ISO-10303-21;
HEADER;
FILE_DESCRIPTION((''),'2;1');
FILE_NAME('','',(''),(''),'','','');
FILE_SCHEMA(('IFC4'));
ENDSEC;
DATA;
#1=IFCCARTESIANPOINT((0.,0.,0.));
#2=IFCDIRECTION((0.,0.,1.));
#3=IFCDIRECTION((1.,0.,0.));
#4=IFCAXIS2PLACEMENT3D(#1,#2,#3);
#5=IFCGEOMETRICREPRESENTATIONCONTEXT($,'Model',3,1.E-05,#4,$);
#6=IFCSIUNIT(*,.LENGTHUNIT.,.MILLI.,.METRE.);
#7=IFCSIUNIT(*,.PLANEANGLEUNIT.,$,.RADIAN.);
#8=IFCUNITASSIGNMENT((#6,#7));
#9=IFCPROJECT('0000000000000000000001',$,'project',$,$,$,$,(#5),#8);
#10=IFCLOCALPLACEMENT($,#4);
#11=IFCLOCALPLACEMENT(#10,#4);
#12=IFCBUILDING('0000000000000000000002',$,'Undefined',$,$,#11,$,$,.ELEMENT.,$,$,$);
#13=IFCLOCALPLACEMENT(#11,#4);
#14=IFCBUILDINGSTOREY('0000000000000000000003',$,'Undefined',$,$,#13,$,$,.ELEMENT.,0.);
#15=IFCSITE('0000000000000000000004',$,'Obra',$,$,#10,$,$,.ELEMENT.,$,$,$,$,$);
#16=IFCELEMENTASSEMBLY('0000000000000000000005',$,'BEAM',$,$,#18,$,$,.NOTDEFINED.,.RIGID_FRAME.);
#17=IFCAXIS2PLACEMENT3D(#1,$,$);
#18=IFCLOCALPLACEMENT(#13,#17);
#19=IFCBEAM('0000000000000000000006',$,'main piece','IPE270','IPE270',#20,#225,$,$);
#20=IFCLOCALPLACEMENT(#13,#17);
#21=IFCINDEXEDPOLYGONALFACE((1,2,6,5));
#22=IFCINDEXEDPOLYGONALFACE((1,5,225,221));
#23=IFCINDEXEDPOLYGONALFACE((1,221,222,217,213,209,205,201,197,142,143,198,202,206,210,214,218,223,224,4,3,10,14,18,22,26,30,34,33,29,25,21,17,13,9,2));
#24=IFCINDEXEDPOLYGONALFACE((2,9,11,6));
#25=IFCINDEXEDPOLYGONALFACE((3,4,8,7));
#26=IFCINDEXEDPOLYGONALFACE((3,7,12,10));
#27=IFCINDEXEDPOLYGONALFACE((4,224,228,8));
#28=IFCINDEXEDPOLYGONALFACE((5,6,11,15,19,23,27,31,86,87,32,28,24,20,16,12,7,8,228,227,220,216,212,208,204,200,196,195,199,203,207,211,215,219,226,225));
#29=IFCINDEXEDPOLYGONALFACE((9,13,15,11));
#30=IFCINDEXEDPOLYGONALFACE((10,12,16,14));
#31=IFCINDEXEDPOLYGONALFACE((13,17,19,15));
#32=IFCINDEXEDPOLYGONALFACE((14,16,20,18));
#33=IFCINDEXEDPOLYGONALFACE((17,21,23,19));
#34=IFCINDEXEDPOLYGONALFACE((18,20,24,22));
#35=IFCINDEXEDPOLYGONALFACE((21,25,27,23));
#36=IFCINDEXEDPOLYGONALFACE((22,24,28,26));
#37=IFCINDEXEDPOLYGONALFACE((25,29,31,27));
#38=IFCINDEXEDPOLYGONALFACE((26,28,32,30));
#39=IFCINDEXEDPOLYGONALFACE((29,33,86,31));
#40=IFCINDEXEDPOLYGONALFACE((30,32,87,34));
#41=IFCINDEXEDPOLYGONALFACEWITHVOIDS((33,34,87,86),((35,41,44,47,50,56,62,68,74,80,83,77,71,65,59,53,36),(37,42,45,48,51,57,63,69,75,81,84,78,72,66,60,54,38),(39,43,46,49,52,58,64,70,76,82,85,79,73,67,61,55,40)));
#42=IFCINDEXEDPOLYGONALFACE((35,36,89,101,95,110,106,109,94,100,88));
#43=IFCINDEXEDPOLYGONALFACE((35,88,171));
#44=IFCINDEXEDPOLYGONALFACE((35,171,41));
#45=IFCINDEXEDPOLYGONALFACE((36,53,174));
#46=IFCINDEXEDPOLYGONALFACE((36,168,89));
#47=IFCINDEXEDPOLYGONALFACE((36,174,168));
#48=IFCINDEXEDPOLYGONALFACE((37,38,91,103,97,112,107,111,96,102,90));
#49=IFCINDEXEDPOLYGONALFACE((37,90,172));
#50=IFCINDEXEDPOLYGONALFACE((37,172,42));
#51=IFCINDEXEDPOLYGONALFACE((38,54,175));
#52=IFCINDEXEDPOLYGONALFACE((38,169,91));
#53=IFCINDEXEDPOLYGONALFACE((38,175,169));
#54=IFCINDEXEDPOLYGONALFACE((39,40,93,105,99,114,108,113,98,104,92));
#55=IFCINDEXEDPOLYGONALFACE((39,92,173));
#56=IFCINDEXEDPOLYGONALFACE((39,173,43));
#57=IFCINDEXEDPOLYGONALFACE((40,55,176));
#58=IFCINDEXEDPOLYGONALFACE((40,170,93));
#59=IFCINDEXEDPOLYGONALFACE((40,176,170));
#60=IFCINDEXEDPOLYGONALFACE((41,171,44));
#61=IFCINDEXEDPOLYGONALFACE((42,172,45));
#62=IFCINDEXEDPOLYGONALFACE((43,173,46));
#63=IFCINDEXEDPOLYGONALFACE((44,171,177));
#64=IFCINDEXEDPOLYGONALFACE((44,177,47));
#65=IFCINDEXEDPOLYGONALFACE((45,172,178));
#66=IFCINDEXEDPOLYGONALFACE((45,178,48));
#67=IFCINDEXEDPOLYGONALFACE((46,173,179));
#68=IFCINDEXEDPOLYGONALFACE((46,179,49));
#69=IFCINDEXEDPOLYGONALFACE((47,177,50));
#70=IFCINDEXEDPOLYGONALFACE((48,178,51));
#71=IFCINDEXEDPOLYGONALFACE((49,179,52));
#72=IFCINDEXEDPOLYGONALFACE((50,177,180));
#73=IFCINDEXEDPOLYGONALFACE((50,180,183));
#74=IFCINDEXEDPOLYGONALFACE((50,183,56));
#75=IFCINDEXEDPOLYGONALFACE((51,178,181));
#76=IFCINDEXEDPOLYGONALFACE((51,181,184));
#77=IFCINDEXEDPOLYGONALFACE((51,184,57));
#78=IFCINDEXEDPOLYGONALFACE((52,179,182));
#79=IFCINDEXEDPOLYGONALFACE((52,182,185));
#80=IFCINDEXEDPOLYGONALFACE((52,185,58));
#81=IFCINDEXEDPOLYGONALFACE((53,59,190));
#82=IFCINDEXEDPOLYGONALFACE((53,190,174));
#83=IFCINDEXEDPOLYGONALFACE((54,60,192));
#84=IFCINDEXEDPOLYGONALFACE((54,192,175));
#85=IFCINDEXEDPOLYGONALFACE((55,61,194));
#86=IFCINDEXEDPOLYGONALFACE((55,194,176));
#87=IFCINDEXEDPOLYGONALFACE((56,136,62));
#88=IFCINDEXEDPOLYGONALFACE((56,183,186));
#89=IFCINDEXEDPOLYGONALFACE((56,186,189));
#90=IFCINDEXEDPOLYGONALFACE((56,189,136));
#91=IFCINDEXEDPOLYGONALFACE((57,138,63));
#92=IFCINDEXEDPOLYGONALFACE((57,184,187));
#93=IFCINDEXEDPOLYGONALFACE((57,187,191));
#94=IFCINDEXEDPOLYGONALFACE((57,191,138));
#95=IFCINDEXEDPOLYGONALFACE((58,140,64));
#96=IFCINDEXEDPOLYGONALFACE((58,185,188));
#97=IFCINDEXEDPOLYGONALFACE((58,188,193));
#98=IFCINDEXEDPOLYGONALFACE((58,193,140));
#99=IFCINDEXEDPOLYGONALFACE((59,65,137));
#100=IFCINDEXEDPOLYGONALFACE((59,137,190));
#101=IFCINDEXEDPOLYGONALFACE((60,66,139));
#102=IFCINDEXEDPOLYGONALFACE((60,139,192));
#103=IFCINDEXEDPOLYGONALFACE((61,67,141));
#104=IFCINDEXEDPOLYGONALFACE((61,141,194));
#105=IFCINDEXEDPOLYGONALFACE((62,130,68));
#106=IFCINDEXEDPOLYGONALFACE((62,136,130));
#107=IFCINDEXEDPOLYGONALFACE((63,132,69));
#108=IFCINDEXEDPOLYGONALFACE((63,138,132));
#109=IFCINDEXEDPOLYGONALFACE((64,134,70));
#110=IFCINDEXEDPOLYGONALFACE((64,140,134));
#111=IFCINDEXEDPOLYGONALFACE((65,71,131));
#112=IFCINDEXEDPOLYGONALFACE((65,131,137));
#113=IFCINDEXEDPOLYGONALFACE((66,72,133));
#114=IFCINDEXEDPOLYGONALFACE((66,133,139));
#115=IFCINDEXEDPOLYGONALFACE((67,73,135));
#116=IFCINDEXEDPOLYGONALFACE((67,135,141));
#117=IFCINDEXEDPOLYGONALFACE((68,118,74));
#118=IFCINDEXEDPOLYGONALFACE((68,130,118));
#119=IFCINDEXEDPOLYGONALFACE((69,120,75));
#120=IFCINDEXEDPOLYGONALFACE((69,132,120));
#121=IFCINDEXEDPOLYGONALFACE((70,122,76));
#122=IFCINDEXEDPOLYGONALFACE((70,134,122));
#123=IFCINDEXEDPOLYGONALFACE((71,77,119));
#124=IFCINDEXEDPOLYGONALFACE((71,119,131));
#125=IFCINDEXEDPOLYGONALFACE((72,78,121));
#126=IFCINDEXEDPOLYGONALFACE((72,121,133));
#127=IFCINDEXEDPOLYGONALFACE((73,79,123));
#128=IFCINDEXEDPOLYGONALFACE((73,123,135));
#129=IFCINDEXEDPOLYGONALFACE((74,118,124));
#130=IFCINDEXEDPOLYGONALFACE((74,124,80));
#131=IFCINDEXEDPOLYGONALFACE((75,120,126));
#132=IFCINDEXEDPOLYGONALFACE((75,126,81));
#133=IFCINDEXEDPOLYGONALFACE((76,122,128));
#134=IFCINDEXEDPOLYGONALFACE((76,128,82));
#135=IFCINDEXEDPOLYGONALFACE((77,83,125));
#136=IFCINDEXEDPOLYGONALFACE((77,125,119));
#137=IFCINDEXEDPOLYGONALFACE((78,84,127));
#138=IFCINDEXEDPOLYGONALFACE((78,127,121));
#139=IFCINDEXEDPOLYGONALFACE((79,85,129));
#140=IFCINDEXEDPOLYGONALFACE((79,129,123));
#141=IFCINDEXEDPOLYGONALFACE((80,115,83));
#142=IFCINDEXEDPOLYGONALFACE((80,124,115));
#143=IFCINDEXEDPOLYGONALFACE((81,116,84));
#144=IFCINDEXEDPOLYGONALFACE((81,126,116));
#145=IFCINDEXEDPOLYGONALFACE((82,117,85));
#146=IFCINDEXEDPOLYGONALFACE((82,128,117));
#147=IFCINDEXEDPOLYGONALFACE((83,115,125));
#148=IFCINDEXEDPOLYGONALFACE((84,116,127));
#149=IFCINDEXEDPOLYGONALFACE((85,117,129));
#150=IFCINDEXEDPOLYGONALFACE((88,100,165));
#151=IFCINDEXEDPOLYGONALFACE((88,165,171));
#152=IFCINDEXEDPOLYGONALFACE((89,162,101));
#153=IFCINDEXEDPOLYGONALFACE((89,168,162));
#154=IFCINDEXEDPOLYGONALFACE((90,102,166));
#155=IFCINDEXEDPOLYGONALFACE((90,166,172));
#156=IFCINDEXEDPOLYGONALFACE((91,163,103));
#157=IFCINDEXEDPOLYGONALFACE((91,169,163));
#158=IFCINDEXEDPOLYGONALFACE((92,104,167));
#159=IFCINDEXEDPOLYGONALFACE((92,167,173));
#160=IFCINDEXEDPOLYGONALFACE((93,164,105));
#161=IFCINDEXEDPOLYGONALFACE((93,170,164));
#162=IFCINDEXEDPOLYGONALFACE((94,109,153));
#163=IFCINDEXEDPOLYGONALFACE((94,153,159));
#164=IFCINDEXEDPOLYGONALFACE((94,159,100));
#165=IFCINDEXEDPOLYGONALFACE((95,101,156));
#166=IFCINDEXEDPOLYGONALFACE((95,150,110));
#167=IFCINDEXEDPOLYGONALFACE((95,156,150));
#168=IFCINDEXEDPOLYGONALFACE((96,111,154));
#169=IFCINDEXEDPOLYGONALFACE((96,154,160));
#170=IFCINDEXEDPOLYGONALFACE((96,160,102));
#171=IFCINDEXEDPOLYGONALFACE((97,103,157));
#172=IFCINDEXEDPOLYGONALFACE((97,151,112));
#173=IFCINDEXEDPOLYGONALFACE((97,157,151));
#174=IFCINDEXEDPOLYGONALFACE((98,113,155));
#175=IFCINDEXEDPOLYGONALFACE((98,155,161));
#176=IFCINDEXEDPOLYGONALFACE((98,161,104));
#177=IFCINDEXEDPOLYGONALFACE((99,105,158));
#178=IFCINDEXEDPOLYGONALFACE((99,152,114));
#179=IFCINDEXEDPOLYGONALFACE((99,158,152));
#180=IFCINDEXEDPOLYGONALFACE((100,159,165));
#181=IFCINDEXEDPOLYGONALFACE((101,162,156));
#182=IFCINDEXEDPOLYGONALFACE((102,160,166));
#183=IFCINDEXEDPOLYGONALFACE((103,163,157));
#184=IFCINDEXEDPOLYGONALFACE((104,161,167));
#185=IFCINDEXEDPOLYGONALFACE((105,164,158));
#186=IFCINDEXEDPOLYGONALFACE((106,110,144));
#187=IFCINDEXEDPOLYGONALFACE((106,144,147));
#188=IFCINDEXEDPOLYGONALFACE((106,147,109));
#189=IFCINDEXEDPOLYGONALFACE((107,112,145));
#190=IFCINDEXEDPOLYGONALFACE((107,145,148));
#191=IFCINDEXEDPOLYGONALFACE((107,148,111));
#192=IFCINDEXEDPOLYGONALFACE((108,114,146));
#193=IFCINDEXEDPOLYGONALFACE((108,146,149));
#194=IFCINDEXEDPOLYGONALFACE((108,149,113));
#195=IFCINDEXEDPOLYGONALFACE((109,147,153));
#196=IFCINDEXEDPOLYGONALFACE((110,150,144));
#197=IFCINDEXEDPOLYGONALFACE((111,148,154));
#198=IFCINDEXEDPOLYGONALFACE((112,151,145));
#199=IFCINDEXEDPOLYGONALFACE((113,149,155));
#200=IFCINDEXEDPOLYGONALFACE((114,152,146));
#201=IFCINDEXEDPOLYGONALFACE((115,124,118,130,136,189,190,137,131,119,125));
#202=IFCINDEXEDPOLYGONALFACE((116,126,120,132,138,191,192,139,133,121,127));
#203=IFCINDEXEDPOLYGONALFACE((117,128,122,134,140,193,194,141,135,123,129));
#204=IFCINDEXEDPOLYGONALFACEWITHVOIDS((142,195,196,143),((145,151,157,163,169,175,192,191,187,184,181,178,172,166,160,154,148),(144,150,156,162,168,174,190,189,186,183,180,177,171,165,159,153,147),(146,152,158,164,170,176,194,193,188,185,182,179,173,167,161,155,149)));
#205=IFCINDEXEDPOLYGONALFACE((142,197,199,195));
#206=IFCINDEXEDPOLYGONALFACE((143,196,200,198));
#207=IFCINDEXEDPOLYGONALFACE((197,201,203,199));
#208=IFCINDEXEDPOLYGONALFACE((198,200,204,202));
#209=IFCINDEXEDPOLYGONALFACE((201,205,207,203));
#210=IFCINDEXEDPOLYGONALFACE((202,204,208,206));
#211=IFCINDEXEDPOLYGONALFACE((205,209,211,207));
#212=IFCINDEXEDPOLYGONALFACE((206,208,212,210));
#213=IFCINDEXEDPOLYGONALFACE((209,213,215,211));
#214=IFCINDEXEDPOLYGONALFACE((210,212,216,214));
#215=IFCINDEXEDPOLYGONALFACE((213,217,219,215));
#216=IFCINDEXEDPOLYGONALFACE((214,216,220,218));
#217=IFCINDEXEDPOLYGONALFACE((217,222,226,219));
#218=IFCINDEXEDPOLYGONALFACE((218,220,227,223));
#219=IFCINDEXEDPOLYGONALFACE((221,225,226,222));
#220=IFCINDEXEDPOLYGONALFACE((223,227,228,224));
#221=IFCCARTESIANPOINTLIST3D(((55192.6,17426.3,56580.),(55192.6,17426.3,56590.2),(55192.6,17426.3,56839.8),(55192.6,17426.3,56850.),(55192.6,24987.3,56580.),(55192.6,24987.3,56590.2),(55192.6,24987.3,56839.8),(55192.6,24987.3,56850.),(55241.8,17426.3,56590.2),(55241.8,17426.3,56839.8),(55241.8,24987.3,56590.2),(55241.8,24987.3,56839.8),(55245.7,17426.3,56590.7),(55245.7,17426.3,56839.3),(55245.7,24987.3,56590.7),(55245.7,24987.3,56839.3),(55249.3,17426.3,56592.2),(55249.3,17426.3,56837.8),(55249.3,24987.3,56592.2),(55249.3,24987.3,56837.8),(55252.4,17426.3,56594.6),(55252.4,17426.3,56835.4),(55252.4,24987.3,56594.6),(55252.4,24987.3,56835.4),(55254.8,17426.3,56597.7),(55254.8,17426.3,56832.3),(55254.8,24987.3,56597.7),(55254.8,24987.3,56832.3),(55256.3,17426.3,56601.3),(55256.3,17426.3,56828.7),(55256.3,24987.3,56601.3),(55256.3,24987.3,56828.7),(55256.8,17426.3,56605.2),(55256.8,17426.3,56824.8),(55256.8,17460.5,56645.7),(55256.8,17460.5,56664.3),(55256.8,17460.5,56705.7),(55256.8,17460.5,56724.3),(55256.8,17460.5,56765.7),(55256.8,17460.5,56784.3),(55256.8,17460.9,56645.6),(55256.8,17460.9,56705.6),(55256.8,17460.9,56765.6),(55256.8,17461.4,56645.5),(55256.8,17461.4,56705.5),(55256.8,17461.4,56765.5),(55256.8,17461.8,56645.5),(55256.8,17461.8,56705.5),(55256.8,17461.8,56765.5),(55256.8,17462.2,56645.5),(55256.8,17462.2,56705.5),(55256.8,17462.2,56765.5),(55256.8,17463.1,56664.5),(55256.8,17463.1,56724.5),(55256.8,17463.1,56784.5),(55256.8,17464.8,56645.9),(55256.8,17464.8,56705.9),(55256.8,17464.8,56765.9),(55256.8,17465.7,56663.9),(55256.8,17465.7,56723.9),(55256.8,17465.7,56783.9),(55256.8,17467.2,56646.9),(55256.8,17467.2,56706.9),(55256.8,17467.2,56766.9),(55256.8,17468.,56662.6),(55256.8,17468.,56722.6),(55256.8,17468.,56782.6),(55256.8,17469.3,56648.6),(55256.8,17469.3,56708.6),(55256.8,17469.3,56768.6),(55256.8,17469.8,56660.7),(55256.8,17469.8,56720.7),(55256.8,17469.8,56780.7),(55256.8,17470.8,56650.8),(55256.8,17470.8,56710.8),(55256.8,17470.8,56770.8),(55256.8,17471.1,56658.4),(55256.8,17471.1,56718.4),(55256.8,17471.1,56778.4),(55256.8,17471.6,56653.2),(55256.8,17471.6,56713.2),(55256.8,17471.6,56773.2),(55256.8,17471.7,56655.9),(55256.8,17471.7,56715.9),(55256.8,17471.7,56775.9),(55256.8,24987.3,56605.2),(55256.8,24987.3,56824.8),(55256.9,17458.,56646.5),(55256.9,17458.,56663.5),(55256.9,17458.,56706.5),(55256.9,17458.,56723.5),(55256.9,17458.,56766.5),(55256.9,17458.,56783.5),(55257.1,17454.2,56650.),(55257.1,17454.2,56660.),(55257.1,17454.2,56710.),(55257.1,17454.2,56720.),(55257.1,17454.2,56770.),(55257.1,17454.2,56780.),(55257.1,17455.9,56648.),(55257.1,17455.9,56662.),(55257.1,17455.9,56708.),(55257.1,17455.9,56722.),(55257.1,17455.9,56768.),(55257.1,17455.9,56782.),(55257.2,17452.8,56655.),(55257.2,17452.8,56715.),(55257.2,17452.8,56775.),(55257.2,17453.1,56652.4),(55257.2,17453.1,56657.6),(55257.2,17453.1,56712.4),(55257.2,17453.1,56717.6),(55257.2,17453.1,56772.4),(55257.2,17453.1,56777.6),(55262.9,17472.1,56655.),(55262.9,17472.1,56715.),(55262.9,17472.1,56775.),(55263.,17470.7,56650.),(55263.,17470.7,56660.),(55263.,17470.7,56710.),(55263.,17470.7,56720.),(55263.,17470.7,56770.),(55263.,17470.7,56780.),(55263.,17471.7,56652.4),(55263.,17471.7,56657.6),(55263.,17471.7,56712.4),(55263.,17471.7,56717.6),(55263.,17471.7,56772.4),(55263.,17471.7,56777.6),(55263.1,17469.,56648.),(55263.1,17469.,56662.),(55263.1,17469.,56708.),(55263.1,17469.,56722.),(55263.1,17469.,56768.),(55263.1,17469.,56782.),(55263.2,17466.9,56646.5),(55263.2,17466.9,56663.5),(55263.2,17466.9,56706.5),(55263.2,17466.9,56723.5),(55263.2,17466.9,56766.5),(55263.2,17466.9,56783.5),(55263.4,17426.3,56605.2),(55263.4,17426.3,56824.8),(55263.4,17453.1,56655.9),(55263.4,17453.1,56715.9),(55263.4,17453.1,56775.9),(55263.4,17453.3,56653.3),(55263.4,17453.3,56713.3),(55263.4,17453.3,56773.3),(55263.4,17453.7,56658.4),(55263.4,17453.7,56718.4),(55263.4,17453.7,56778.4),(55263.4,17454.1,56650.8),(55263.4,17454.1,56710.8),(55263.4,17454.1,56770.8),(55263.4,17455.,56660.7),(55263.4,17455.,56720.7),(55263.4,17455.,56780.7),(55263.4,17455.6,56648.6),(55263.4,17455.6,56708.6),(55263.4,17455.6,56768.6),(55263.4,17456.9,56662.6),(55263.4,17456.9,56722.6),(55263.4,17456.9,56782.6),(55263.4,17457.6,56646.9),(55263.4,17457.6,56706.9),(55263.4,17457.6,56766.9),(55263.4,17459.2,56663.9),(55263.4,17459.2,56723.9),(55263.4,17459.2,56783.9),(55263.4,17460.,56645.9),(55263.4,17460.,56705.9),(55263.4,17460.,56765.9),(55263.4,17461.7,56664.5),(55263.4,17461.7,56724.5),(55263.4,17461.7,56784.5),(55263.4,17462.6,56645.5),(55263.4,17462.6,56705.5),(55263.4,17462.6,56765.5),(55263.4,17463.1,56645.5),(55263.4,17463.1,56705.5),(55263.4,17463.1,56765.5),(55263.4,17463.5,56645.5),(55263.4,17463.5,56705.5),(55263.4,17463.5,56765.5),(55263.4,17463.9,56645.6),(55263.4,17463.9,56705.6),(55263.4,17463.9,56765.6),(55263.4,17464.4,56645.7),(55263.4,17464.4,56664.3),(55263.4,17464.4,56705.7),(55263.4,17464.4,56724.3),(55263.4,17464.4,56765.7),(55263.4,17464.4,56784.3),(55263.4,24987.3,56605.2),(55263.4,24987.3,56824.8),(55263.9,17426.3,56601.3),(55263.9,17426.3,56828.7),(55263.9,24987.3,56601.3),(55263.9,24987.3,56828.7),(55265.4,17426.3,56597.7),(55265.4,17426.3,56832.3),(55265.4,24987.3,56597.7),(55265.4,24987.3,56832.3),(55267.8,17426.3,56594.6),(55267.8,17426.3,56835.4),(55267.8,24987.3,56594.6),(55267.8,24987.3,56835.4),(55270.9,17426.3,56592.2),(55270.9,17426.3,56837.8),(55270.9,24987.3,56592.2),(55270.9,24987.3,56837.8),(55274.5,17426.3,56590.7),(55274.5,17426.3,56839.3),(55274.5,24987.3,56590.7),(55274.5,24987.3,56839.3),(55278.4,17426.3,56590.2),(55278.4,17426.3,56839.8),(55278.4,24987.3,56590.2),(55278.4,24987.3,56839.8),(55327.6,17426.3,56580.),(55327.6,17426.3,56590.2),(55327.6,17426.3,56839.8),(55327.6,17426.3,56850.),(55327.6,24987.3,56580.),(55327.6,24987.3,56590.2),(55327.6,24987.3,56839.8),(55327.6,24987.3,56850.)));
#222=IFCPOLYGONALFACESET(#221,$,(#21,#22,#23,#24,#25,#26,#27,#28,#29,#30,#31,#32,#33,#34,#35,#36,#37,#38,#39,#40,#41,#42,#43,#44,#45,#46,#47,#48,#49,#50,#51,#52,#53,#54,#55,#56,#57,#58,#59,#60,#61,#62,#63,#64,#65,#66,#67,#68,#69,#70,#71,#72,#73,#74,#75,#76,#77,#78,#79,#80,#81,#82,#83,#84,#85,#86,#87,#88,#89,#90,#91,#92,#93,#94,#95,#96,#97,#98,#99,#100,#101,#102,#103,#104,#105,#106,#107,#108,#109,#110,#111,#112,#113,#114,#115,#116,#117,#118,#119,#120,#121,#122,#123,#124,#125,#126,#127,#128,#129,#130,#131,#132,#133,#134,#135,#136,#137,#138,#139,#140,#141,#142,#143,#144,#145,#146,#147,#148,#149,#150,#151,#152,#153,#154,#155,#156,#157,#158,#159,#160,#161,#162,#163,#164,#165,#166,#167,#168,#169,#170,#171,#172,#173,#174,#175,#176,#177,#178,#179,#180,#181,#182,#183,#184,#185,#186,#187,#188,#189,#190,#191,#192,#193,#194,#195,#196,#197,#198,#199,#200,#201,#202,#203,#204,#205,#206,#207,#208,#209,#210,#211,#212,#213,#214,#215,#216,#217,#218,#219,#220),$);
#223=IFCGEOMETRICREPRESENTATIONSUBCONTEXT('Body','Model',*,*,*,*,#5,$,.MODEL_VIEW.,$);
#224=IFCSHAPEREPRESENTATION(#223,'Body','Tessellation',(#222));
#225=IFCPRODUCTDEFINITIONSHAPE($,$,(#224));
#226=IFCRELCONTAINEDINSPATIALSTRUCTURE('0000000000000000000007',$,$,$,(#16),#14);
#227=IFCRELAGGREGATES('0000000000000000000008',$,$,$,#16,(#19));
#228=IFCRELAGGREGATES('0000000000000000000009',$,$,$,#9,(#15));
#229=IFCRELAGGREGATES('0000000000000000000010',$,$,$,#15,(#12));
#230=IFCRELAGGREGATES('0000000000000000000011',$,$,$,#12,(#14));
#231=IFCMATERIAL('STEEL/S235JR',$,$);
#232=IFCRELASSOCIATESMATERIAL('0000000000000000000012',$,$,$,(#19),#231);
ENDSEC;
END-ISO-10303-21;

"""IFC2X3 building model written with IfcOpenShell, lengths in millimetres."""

from ifc_helpers import new_model, si_unit, frame, origin_with_axes, origin_2d_with_axis, place, context, subcontext, project, spatial, circle, i_section, extrude, clip, halfspace, source, transform, mapped, material, element, aggregate, save


model = new_model("IFC2X3")

# Units and contexts
model_context = context("Model", 3, precision=1e-05, world=origin_with_axes())
body_context = subcontext(model_context, "Body", "Model", "MODEL_VIEW")
ifc_project = project(units=[si_unit("LENGTHUNIT", "METRE", prefix="MILLI"), si_unit("PLANEANGLEUNIT", "RADIAN")], contexts=[model_context])

# Site, building, storey
site_placement = place(None, origin_with_axes())
site = spatial("IfcSite", under=ifc_project, at=site_placement, Name="Obra", CompositionType="ELEMENT")
building_placement = place(site_placement, origin_with_axes())
building = spatial("IfcBuilding", under=site, at=building_placement, Name="Undefined", CompositionType="ELEMENT")
storey_placement = place(building_placement, origin_with_axes())
storey = spatial("IfcBuildingStorey", under=building, at=storey_placement, Name="Undefined", CompositionType="ELEMENT", Elevation=0.0)

# Shared definitions
ifc_material_1 = material(Name="STEEL/S235JR")

# Element assembly, beam, opening
assembly_1_placement = place(storey_placement, origin_with_axes())
assembly_1 = element("IfcElementAssembly", 1, at=assembly_1_placement, inside=storey, Name="BEAM", AssemblyPlace="NOTDEFINED", PredefinedType="RIGID_FRAME")
beam_1_placement = place(assembly_1_placement, frame((55260.1, 24987.3, 56715.0), z_axis=(0.0, 0.0, 1.0), x_axis=(0.0, -1.0, 0.0)))
beam_1 = element("IfcBeam", 2, at=beam_1_placement, material=ifc_material_1, Name="main piece", Description="IPE270", ObjectType="IPE270", context=body_context, shape_type="Clipping", body=[
    clip(extrude(i_section(OverallWidth=135.0, OverallDepth=270.0, WebThickness=6.6, FlangeThickness=10.2, FilletRadius=15.0, at=origin_2d_with_axis()), frame((7560.9, 0.0, 0.0), z_axis=(-1.0, 0.0, 0.0), x_axis=(0.0, -1.0, 0.0)), (0.0, 0.0, 1.0), 7560.9), halfspace(frame((7579.6, -89.1, -120.0), z_axis=(0.998367, 0.057126, 0.0), x_axis=(0.0, 0.0, 1.0)), False)),
])
shared_shape_1 = source(origin_with_axes(), body_context, "Body", "SweptSolid", [
    extrude(circle(Radius=9.5, at=origin_2d_with_axis()), frame((0.0, -35.4, 0.0), z_axis=(0.0, 1.0, 0.0), x_axis=(1.0, 0.0, 0.0)), (0.0, 0.0, 1.0), 6.8),
])
opening_1_placement = place(assembly_1_placement, frame((55231.0, 17410.7, 56835.0), z_axis=(-0.057107, 0.998368, 0.0), x_axis=(0.0, 0.0, -1.0)))
element("IfcOpeningElement", 3, at=opening_1_placement, cuts=beam_1, ObjectType="Opening", context=body_context, shape_type="MappedRepresentation", body=[
    mapped(shared_shape_1, transform((60.0, 0.0, 50.0))),
    mapped(shared_shape_1, transform((120.0, 0.0, 50.0))),
    mapped(shared_shape_1, transform((180.0, 0.0, 50.0))),
])
aggregate(assembly_1, [beam_1])

save(model, "model.ifc")
